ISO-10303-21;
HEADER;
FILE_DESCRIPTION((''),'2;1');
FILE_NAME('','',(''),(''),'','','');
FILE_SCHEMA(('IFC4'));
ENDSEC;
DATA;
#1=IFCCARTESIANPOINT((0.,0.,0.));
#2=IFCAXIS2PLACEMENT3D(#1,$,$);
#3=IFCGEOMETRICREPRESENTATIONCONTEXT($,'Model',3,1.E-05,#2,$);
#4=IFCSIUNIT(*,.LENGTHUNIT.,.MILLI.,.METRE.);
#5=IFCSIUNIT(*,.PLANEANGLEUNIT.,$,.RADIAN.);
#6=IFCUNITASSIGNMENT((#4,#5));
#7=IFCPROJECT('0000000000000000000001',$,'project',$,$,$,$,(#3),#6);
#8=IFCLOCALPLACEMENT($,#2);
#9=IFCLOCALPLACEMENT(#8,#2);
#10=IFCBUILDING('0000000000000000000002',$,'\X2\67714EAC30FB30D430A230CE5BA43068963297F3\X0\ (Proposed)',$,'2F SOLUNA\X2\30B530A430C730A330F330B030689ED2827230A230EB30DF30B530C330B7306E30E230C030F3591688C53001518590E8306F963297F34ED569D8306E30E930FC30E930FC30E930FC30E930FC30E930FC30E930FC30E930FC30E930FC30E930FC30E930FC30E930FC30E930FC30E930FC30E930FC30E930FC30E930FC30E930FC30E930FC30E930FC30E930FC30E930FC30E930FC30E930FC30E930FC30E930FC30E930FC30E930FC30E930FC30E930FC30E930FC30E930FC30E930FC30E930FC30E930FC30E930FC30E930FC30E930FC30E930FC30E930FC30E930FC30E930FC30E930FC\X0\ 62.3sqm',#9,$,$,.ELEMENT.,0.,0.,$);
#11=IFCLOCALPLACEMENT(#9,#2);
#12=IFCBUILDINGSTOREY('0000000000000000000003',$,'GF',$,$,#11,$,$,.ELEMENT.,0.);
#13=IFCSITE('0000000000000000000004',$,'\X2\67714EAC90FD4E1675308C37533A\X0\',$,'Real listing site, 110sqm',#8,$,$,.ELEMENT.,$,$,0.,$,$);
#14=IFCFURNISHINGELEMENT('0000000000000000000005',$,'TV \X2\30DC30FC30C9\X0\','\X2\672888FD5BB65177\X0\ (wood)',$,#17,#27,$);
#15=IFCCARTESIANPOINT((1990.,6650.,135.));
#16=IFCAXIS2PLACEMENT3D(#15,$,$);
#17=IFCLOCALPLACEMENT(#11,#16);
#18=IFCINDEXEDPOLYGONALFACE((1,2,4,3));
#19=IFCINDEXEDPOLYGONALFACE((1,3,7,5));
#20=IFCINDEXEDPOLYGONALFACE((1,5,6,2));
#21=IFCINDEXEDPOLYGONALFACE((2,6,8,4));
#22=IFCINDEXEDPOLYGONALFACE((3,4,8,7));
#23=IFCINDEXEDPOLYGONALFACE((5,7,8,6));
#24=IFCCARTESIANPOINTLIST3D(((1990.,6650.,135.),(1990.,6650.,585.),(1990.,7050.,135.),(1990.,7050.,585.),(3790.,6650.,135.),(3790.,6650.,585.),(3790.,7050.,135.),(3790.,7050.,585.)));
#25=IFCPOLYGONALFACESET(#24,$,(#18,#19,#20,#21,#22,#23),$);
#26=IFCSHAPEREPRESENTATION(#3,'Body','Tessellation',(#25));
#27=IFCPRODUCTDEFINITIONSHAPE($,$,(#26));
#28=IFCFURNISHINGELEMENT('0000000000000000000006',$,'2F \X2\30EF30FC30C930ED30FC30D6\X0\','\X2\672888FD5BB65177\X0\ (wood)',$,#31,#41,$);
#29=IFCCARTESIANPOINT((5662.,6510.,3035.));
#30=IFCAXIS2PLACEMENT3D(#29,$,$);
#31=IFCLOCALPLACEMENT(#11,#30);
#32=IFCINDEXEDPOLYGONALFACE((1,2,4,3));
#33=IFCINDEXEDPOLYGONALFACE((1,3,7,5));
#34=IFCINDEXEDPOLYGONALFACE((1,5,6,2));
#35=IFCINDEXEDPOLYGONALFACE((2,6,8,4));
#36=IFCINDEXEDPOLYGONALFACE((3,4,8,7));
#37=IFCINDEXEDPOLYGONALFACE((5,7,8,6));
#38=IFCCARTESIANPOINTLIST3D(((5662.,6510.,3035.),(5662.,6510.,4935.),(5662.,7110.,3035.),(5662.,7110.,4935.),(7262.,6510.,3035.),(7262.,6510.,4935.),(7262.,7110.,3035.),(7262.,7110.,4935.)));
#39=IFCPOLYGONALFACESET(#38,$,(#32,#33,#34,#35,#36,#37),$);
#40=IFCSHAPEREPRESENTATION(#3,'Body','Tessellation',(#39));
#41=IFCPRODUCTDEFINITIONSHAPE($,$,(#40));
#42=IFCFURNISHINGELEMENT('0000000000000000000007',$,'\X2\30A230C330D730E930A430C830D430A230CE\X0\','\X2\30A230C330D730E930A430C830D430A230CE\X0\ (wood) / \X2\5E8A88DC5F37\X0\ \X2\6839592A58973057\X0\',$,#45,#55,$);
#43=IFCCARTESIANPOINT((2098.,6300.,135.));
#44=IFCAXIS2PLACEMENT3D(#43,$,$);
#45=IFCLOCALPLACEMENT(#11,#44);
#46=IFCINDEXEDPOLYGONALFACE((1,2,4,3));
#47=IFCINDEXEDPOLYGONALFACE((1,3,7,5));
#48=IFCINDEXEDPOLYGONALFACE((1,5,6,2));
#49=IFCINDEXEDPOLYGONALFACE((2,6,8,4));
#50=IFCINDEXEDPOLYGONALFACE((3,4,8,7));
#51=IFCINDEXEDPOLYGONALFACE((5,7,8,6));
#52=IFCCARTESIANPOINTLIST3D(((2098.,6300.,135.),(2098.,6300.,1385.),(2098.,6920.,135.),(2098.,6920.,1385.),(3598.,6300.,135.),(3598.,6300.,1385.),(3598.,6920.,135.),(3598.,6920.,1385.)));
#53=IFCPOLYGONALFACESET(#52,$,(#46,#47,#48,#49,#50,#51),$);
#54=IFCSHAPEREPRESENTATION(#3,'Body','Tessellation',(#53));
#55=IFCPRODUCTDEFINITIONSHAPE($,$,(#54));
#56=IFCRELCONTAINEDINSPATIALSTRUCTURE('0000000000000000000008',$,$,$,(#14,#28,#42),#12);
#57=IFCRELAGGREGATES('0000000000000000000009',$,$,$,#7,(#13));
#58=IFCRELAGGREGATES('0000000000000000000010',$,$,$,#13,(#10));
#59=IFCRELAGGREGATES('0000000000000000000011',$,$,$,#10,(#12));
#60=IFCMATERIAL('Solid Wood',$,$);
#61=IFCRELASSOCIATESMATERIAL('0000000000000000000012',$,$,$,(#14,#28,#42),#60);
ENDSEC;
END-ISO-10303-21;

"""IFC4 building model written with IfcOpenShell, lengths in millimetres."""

from ifc_helpers import new_model, si_unit, frame, frame_2d, origin, place, context, project, spatial, rectangle, extrude, material, element, save


model = new_model("IFC4")

# Units and contexts
model_context = context("Model", 3, precision=1e-05, world=origin())
ifc_project = project(units=[si_unit("LENGTHUNIT", "METRE", prefix="MILLI"), si_unit("PLANEANGLEUNIT", "RADIAN")], contexts=[model_context])

# Site, building, storey
site_placement = place(None, origin())
site = spatial("IfcSite", under=ifc_project, at=site_placement, Name="東京都世田谷区", ObjectType="Real listing site, 110sqm", CompositionType="ELEMENT", RefElevation=0.0)
building_placement = place(site_placement, origin())
building = spatial("IfcBuilding", under=site, at=building_placement, Name="東京・ピアノ室と防音 (Proposed)", ObjectType="2F SOLUNAサイディングと黒色アルミサッシのモダン外装、内部は防音仕様のラーラーラーラーラーラーラーラーラーラーラーラーラーラーラーラーラーラーラーラーラーラーラーラーラーラーラーラーラーラーラーラーラーラーラーラーラーラーラーラーラーラー 62.3sqm", CompositionType="ELEMENT", ElevationOfRefHeight=0.0, ElevationOfTerrain=0.0)
storey_placement = place(building_placement, origin())
storey = spatial("IfcBuildingStorey", under=building, at=storey_placement, Name="GF", CompositionType="ELEMENT", Elevation=0.0)

# Shared definitions
ifc_material_1 = material(Name="Solid Wood")

# Furnishing elements
furnishing_1_placement = place(storey_placement, frame((1990.0, 6650.0, 135.0)))
element("IfcFurnishingElement", 1, at=furnishing_1_placement, inside=storey, material=ifc_material_1, Name="TV ボード", Description="木製家具 (wood)", context=model_context, shape_type="SweptSolid", body=[
    extrude(rectangle(XDim=1800.0, YDim=400.0, at=frame_2d((900.0, 200.0))), frame((1990.0, 6650.0, 135.0)), (0.0, 0.0, 1.0), 450.0),
])
furnishing_2_placement = place(storey_placement, frame((5662.0, 6510.0, 3035.0)))
element("IfcFurnishingElement", 2, at=furnishing_2_placement, inside=storey, material=ifc_material_1, Name="2F ワードローブ", Description="木製家具 (wood)", context=model_context, shape_type="SweptSolid", body=[
    extrude(rectangle(XDim=1600.0, YDim=600.0, at=frame_2d((800.0, 300.0))), frame((5662.0, 6510.0, 3035.0)), (0.0, 0.0, 1.0), 1900.0),
])
furnishing_3_placement = place(storey_placement, frame((2098.0, 6300.0, 135.0)))
element("IfcFurnishingElement", 3, at=furnishing_3_placement, inside=storey, material=ifc_material_1, Name="アップライトピアノ", Description="アップライトピアノ (wood) / 床補強 根太増し", context=model_context, shape_type="SweptSolid", body=[
    extrude(rectangle(XDim=1500.0, YDim=620.0, at=frame_2d((750.0, 310.0))), frame((2098.0, 6300.0, 135.0)), (0.0, 0.0, 1.0), 1250.0),
])

save(model, "model.ifc")
